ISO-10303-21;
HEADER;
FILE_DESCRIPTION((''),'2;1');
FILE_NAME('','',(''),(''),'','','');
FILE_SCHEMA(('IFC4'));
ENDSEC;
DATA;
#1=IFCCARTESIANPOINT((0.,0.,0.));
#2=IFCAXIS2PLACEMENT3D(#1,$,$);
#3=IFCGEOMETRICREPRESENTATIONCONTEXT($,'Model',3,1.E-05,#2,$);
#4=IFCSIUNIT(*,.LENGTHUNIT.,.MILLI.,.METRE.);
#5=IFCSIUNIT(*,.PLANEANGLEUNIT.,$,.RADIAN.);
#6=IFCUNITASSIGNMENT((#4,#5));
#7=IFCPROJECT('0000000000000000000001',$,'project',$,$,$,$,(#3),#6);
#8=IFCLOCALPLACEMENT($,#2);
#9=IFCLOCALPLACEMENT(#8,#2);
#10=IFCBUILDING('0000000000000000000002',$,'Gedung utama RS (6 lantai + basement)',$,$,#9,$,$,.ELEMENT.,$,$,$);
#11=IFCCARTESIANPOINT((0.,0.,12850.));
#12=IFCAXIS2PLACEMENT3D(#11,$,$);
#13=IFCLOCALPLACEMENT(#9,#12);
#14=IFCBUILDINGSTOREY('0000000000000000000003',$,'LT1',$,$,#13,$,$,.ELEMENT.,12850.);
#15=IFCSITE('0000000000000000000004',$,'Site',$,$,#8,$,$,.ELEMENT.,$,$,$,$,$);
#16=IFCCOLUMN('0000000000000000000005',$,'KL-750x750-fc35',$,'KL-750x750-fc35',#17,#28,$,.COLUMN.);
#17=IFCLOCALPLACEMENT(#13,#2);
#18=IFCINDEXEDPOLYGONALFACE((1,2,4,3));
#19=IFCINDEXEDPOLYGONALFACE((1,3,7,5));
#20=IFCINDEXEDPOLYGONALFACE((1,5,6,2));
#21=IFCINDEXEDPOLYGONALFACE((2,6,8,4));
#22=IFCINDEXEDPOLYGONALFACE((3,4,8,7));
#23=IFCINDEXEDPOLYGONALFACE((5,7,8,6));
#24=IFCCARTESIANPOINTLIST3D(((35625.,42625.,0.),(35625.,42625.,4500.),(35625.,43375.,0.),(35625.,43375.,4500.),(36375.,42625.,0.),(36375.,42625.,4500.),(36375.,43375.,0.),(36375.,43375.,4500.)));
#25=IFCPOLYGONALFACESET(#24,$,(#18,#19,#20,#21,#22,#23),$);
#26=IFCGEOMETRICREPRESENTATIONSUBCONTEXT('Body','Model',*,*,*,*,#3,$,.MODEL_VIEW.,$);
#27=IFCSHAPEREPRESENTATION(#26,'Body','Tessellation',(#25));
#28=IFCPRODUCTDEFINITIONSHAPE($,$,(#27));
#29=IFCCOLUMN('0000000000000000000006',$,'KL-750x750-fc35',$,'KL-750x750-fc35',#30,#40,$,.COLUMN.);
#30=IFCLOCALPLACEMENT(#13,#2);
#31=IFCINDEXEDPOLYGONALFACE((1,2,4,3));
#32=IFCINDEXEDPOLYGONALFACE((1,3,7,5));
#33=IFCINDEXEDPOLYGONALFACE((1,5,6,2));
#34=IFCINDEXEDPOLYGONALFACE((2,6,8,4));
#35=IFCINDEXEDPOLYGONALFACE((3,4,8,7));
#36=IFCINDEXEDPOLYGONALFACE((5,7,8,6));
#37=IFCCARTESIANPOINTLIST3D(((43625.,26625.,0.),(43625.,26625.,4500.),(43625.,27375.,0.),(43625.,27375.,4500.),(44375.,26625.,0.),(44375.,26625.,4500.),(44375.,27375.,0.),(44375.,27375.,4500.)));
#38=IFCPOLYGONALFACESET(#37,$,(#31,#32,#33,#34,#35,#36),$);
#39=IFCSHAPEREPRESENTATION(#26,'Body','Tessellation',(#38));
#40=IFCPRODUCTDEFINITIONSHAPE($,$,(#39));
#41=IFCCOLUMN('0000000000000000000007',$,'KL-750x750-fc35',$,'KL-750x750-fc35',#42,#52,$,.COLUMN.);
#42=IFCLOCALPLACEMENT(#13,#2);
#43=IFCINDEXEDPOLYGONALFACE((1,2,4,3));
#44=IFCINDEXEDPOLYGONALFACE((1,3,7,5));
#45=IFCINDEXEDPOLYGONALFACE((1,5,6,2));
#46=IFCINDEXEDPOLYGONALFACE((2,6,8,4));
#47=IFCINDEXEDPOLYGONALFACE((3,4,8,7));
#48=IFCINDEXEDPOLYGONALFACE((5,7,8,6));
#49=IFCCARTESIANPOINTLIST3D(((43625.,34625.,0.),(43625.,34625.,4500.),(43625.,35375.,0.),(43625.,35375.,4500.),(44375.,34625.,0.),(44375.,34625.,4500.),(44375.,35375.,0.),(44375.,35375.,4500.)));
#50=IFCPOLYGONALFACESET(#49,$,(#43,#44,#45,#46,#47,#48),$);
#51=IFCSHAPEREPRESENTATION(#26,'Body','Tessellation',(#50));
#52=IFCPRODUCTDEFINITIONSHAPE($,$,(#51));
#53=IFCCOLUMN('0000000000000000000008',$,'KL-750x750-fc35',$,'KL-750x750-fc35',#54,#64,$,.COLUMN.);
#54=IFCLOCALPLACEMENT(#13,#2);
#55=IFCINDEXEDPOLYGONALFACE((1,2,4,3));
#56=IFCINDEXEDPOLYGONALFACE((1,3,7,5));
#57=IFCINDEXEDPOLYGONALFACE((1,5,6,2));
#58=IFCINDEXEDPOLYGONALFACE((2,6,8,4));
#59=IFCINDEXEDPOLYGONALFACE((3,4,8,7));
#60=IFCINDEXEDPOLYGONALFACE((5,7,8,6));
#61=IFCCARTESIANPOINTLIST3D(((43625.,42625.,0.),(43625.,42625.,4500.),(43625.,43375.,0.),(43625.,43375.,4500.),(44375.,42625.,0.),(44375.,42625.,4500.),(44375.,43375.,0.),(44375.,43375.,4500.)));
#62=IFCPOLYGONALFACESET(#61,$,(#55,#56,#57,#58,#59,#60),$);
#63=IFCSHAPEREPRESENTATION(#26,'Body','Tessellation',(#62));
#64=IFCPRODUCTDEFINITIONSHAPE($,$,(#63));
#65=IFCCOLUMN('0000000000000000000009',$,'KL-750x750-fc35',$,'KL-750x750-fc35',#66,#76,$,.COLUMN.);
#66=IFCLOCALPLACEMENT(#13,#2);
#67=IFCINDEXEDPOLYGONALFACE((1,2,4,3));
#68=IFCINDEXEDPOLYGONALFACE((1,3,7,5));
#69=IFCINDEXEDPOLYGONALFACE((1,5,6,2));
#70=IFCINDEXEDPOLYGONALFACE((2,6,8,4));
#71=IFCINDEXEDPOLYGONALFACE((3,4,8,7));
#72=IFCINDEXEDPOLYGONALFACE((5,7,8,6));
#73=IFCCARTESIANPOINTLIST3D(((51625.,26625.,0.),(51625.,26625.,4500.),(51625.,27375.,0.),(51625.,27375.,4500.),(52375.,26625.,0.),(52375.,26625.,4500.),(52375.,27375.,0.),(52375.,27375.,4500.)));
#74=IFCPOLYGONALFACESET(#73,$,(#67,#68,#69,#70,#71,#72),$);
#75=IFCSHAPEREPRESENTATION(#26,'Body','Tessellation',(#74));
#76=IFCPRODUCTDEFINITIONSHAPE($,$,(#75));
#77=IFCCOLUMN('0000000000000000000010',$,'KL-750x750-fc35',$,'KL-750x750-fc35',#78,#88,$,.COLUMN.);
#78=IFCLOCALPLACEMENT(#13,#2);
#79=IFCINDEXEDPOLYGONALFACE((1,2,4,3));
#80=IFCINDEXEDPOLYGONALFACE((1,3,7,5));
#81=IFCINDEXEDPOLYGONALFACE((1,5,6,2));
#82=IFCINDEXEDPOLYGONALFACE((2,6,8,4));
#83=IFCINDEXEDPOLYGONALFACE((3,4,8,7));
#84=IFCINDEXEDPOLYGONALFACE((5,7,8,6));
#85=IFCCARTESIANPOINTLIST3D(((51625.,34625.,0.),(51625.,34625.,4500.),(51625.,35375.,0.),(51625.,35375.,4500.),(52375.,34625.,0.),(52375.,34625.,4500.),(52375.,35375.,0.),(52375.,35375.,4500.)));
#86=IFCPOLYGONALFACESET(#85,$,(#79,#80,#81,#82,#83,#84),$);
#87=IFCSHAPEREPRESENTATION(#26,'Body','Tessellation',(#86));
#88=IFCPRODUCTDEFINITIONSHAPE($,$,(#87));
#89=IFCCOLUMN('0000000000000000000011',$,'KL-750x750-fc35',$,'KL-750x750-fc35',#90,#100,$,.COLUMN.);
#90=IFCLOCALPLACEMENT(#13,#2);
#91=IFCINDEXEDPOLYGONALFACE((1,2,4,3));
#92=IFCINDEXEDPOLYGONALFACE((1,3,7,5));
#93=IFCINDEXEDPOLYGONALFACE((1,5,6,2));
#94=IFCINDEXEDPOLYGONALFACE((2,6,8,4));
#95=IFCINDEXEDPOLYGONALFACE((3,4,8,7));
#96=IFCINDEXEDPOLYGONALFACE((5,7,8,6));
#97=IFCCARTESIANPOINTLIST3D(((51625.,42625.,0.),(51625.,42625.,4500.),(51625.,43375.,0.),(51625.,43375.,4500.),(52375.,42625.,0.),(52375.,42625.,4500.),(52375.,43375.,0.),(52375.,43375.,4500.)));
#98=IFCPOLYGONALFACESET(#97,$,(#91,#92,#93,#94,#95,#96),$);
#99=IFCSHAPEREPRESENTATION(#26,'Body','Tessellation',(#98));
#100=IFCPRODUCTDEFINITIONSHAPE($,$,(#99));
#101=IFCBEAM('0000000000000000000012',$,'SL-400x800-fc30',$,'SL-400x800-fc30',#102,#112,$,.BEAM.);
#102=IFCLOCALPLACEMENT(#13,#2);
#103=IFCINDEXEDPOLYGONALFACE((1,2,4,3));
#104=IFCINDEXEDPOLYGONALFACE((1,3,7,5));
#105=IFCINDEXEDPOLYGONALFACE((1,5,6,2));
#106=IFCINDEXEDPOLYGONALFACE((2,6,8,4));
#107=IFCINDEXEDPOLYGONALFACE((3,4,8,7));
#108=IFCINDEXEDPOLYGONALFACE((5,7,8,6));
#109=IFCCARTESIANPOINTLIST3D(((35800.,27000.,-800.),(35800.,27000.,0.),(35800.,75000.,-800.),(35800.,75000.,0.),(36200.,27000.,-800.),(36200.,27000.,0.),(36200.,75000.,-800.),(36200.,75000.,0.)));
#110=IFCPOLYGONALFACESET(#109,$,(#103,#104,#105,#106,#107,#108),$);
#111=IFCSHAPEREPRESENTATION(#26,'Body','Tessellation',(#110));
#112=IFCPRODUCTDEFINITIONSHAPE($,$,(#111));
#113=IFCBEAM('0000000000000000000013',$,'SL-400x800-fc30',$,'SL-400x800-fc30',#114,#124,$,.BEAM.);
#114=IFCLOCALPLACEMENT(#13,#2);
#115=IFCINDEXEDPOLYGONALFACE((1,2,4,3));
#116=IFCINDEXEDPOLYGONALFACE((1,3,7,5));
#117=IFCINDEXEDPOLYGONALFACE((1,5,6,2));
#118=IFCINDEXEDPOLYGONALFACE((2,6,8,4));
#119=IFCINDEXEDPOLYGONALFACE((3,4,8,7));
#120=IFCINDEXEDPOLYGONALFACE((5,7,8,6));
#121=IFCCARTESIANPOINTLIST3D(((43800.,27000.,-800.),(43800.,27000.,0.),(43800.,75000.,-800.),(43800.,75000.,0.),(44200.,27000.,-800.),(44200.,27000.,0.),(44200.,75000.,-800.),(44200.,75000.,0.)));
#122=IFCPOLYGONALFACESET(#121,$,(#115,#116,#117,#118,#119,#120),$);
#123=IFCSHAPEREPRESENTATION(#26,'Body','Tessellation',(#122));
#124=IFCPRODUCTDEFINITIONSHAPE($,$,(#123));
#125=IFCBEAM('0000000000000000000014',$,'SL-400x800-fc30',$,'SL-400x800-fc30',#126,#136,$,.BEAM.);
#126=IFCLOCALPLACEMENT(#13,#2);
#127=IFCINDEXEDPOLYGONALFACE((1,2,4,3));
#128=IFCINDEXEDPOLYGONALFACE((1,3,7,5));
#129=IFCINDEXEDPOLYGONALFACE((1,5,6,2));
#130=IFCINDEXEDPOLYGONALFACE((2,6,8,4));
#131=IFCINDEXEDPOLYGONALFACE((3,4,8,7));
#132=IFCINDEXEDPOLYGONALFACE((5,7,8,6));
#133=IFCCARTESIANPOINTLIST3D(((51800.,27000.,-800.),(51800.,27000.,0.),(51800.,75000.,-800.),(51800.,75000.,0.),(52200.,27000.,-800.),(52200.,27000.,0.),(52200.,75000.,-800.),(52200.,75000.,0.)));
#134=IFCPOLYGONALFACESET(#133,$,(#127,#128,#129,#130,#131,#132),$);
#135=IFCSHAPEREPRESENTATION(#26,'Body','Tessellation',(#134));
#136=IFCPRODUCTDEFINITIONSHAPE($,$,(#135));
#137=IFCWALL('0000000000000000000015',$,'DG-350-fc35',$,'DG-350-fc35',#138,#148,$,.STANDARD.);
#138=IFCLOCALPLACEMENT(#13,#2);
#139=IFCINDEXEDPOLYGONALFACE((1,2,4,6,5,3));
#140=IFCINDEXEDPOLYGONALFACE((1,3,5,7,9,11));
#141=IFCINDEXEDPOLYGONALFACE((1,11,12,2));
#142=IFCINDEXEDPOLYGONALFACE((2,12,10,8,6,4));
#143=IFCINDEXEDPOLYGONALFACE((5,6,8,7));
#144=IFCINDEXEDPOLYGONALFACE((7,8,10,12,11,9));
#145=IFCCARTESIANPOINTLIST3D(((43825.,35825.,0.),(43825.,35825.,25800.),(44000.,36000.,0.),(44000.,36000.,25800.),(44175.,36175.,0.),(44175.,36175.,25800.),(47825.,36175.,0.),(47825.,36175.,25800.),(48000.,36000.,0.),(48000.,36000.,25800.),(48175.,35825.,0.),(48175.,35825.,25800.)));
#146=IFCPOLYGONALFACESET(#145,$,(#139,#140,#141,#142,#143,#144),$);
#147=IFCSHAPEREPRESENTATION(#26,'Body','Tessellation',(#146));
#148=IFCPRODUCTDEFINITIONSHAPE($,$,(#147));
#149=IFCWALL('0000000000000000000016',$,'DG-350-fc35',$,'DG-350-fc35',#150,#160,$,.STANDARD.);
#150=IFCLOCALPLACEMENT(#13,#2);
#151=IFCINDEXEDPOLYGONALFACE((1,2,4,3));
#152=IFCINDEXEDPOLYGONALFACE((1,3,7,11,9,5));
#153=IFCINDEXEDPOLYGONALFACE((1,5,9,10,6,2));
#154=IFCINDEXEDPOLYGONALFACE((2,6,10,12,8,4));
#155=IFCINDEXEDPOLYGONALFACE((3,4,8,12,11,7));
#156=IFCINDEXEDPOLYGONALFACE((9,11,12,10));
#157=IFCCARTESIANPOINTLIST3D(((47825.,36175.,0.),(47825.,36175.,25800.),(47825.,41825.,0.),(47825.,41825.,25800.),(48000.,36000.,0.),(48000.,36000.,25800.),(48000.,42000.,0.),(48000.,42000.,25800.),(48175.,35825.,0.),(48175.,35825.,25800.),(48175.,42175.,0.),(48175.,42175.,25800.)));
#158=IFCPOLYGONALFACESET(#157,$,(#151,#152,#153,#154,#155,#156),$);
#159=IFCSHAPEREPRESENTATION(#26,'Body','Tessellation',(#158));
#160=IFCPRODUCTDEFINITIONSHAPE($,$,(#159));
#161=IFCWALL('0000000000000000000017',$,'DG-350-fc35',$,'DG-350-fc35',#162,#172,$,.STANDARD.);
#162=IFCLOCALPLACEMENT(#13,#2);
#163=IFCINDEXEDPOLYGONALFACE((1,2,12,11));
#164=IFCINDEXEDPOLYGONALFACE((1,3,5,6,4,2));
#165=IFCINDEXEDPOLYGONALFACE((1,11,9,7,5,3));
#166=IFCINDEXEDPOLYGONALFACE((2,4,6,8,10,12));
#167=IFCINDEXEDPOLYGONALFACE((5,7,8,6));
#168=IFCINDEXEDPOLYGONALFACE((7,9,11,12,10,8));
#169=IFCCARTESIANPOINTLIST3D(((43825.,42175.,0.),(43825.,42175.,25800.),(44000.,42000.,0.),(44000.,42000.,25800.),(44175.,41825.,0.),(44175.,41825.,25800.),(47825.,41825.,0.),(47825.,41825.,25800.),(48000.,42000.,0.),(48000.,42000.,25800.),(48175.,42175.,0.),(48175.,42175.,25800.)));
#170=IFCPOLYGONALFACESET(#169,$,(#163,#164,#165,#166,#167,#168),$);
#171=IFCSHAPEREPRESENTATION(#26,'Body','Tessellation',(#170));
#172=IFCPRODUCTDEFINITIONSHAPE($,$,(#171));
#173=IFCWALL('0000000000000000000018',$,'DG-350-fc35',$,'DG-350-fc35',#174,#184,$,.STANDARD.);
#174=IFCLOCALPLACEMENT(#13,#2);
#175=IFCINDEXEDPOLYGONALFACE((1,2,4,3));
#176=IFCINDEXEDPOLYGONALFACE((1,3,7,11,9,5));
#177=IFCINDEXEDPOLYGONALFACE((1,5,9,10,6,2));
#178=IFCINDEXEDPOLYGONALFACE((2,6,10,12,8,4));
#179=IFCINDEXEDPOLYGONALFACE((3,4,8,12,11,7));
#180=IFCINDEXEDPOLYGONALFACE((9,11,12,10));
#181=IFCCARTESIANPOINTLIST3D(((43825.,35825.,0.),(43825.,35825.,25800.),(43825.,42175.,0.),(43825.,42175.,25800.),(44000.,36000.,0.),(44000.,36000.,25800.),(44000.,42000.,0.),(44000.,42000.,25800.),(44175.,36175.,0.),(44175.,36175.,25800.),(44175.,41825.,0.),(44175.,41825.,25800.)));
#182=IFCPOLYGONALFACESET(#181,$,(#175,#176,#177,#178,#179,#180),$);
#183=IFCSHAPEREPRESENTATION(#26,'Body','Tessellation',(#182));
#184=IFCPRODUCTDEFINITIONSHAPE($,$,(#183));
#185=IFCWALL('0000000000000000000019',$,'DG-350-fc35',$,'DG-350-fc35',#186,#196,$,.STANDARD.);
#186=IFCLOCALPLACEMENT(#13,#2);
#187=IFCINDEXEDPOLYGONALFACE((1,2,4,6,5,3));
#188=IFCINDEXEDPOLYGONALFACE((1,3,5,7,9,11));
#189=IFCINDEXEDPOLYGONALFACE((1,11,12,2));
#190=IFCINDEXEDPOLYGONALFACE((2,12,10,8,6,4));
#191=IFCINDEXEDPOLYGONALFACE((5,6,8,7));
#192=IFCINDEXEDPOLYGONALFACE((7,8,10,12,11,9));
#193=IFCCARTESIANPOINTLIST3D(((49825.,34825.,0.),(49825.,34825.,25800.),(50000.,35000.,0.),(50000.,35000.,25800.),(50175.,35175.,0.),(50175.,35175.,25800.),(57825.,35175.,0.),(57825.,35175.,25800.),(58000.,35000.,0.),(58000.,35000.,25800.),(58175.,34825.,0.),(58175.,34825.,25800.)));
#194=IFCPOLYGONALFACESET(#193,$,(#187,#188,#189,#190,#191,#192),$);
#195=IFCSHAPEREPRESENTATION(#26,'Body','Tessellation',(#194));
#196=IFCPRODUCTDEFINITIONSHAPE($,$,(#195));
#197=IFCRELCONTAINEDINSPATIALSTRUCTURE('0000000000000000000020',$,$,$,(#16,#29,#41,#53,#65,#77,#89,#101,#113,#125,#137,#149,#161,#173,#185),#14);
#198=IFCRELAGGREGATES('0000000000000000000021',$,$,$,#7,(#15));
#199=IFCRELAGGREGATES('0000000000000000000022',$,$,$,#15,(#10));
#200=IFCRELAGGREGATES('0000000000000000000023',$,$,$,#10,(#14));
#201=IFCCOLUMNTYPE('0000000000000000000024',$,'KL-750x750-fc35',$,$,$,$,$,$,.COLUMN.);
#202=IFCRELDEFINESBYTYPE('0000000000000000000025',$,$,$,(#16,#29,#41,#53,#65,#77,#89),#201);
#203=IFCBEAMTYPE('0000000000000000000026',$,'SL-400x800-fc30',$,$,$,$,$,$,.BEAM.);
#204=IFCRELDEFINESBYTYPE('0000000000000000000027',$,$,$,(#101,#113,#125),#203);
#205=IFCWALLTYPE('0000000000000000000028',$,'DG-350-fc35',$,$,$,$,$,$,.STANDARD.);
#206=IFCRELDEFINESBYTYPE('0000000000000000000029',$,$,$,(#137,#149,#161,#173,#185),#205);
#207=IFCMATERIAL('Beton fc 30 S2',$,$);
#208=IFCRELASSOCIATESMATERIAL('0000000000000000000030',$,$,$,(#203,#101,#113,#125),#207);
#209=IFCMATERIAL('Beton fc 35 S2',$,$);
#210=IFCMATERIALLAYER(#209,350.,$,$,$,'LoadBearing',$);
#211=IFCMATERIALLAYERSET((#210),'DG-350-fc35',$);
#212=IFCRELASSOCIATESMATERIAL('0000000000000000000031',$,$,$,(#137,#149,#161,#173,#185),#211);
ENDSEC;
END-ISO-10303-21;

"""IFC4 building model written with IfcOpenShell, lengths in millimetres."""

from ifc_helpers import new_model, si_unit, frame, origin, origin_2d, place, context, subcontext, project, spatial, polyline, rectangle, outline, extrude, material, layer, layer_set, layer_usage, material_profile, profile_set, profile_usage, type_object, element, save


model = new_model("IFC4")

# Units and contexts
model_context = context("Model", 3, precision=1e-05, world=origin())
body_context = subcontext(model_context, "Body", "Model", "MODEL_VIEW")
ifc_project = project(units=[si_unit("LENGTHUNIT", "METRE", prefix="MILLI"), si_unit("PLANEANGLEUNIT", "RADIAN")], contexts=[model_context])

# Site, building, storey
site_placement = place(None, origin())
site = spatial("IfcSite", under=ifc_project, at=site_placement, Name="Site", CompositionType="ELEMENT")
building_placement = place(site_placement, origin())
building = spatial("IfcBuilding", under=site, at=building_placement, Name="Gedung utama RS (6 lantai + basement)", CompositionType="ELEMENT")
storey_placement = place(building_placement, frame((0.0, 0.0, 12850.0)))
storey = spatial("IfcBuildingStorey", under=building, at=storey_placement, Name="LT1", CompositionType="ELEMENT", Elevation=12850.0)

# Columns
ifc_material_profile_1 = material_profile(None, rectangle(XDim=750.0, YDim=750.0, at=origin_2d()), Name="KL-750x750-fc35")
ifc_profile_set_1 = profile_set([ifc_material_profile_1], Name="KL-750x750-fc35")
ifc_profile_usage_1 = profile_usage(ifc_profile_set_1, cardinal=5)
column_type = type_object("IfcColumnType", Name="KL-750x750-fc35", PredefinedType="COLUMN", material=ifc_profile_set_1)
for number, where, z_axis, x_axis, name in (
    (1, (36000.0, 43000.0, 0.0), (0.0, 0.0, 1.0), (1.0, 0.0, 0.0), "KL-750x750-fc35"),
    (2, (44000.0, 27000.0, 0.0), (0.0, 0.0, 1.0), (1.0, 0.0, 0.0), "KL-750x750-fc35"),
    (3, (44000.0, 35000.0, 0.0), (0.0, 0.0, 1.0), (1.0, 0.0, 0.0), "KL-750x750-fc35"),
    (4, (44000.0, 43000.0, 0.0), (0.0, 0.0, 1.0), (1.0, 0.0, 0.0), "KL-750x750-fc35"),
    (5, (52000.0, 27000.0, 0.0), (0.0, 0.0, 1.0), (1.0, 0.0, 0.0), "KL-750x750-fc35"),
    (6, (52000.0, 35000.0, 0.0), (0.0, 0.0, 1.0), (1.0, 0.0, 0.0), "KL-750x750-fc35"),
    (7, (52000.0, 43000.0, 0.0), (0.0, 0.0, 1.0), (1.0, 0.0, 0.0), "KL-750x750-fc35"),
):
    element("IfcColumn", number, at=place(storey_placement, frame(where, z_axis=z_axis, x_axis=x_axis)), inside=storey, type_object=column_type, material=ifc_profile_usage_1, Name=name, ObjectType="KL-750x750-fc35", PredefinedType="COLUMN", context=body_context, shape_type="SweptSolid", body=[
        extrude(rectangle(XDim=750.0, YDim=750.0, at=origin_2d()), origin(), (0.0, 0.0, 1.0), 4500.0),
    ])

# Beams
ifc_material_1 = material(Name="Beton fc 30 S2")
ifc_material_profile_2 = material_profile(ifc_material_1, rectangle(XDim=400.0, YDim=800.0, at=origin_2d()), Name="SL-400x800-fc30")
ifc_profile_set_2 = profile_set([ifc_material_profile_2], Name="SL-400x800-fc30")
ifc_profile_usage_2 = profile_usage(ifc_profile_set_2, cardinal=8)
beam_type = type_object("IfcBeamType", Name="SL-400x800-fc30", PredefinedType="BEAM", material=ifc_profile_set_2)
for number, where, name in (
    (8, (36000.0, 27000.0, -400.0), "SL-400x800-fc30"),
    (9, (44000.0, 27000.0, -400.0), "SL-400x800-fc30"),
    (10, (52000.0, 27000.0, -400.0), "SL-400x800-fc30"),
):
    element("IfcBeam", number, at=place(storey_placement, frame(where)), inside=storey, type_object=beam_type, material=ifc_profile_usage_2, Name=name, ObjectType="SL-400x800-fc30", PredefinedType="BEAM", context=body_context, shape_type="SweptSolid", body=[
        extrude(rectangle(XDim=400.0, YDim=800.0, at=origin_2d()), frame((0.0, 0.0, 0.0), z_axis=(0.0, 1.0, 0.0), x_axis=(-1.0, 0.0, 0.0)), (0.0, 0.0, 1.0), 48000.0),
    ])

# Walls
ifc_material_2 = material(Name="Beton fc 35 S2")
ifc_layer = layer(ifc_material_2, 350.0, Category="LoadBearing")
ifc_layer_set = layer_set([ifc_layer], Name="DG-350-fc35")
ifc_layer_usage = layer_usage(ifc_layer_set, "AXIS2", "NEGATIVE", 175.0)
wall_type = type_object("IfcWallType", Name="DG-350-fc35", PredefinedType="STANDARD")
wall_1_placement = place(storey_placement, frame((44000.0, 36000.0, 0.0), z_axis=(0.0, 0.0, 1.0), x_axis=(1.0, 0.0, 0.0)))
element("IfcWall", 11, at=wall_1_placement, inside=storey, type_object=wall_type, material=ifc_layer_usage, Name="DG-350-fc35", ObjectType="DG-350-fc35", PredefinedType="STANDARD", context=body_context, shape_type="SweptSolid", body=[
    extrude(outline(polyline([(-175.0, -175.0), (0.0, 0.0), (175.0, 175.0), (3825.0, 175.0), (4000.0, 0.0), (4175.0, -175.0), (-175.0, -175.0)])), origin(), (0.0, 0.0, 1.0), 25800.0),
])
wall_2_placement = place(storey_placement, frame((48000.0, 36000.0, 0.0), z_axis=(0.0, 0.0, 1.0), x_axis=(0.0, 1.0, 0.0)))
element("IfcWall", 12, at=wall_2_placement, inside=storey, type_object=wall_type, material=ifc_layer_usage, Name="DG-350-fc35", ObjectType="DG-350-fc35", PredefinedType="STANDARD", context=body_context, shape_type="SweptSolid", body=[
    extrude(outline(polyline([(-175.0, -175.0), (0.0, 0.0), (175.0, 175.0), (5825.0, 175.0), (6000.0, 0.0), (6175.0, -175.0), (-175.0, -175.0)])), origin(), (0.0, 0.0, 1.0), 25800.0),
])
wall_3_placement = place(storey_placement, frame((48000.0, 42000.0, 0.0), z_axis=(0.0, 0.0, 1.0), x_axis=(-1.0, 0.0, 0.0)))
element("IfcWall", 13, at=wall_3_placement, inside=storey, type_object=wall_type, material=ifc_layer_usage, Name="DG-350-fc35", ObjectType="DG-350-fc35", PredefinedType="STANDARD", context=body_context, shape_type="SweptSolid", body=[
    extrude(outline(polyline([(-175.0, -175.0), (0.0, 0.0), (175.0, 175.0), (3825.0, 175.0), (4000.0, 0.0), (4175.0, -175.0), (-175.0, -175.0)])), origin(), (0.0, 0.0, 1.0), 25800.0),
])
wall_4_placement = place(storey_placement, frame((44000.0, 42000.0, 0.0), z_axis=(0.0, 0.0, 1.0), x_axis=(0.0, -1.0, 0.0)))
element("IfcWall", 14, at=wall_4_placement, inside=storey, type_object=wall_type, material=ifc_layer_usage, Name="DG-350-fc35", ObjectType="DG-350-fc35", PredefinedType="STANDARD", context=body_context, shape_type="SweptSolid", body=[
    extrude(outline(polyline([(-175.0, -175.0), (0.0, 0.0), (175.0, 175.0), (5825.0, 175.0), (6000.0, 0.0), (6175.0, -175.0), (-175.0, -175.0)])), origin(), (0.0, 0.0, 1.0), 25800.0),
])
for number, where, z_axis, x_axis, name in (
    (15, (50000.0, 35000.0, 0.0), (0.0, 0.0, 1.0), (1.0, 0.0, 0.0), "DG-350-fc35"),
):
    element("IfcWall", number, at=place(storey_placement, frame(where, z_axis=z_axis, x_axis=x_axis)), inside=storey, type_object=wall_type, material=ifc_layer_usage, Name=name, ObjectType="DG-350-fc35", PredefinedType="STANDARD", context=body_context, shape_type="SweptSolid", body=[
        extrude(outline(polyline([(-175.0, -175.0), (0.0, 0.0), (175.0, 175.0), (7825.0, 175.0), (8000.0, 0.0), (8175.0, -175.0), (-175.0, -175.0)])), origin(), (0.0, 0.0, 1.0), 25800.0),
    ])

save(model, "model.ifc")
